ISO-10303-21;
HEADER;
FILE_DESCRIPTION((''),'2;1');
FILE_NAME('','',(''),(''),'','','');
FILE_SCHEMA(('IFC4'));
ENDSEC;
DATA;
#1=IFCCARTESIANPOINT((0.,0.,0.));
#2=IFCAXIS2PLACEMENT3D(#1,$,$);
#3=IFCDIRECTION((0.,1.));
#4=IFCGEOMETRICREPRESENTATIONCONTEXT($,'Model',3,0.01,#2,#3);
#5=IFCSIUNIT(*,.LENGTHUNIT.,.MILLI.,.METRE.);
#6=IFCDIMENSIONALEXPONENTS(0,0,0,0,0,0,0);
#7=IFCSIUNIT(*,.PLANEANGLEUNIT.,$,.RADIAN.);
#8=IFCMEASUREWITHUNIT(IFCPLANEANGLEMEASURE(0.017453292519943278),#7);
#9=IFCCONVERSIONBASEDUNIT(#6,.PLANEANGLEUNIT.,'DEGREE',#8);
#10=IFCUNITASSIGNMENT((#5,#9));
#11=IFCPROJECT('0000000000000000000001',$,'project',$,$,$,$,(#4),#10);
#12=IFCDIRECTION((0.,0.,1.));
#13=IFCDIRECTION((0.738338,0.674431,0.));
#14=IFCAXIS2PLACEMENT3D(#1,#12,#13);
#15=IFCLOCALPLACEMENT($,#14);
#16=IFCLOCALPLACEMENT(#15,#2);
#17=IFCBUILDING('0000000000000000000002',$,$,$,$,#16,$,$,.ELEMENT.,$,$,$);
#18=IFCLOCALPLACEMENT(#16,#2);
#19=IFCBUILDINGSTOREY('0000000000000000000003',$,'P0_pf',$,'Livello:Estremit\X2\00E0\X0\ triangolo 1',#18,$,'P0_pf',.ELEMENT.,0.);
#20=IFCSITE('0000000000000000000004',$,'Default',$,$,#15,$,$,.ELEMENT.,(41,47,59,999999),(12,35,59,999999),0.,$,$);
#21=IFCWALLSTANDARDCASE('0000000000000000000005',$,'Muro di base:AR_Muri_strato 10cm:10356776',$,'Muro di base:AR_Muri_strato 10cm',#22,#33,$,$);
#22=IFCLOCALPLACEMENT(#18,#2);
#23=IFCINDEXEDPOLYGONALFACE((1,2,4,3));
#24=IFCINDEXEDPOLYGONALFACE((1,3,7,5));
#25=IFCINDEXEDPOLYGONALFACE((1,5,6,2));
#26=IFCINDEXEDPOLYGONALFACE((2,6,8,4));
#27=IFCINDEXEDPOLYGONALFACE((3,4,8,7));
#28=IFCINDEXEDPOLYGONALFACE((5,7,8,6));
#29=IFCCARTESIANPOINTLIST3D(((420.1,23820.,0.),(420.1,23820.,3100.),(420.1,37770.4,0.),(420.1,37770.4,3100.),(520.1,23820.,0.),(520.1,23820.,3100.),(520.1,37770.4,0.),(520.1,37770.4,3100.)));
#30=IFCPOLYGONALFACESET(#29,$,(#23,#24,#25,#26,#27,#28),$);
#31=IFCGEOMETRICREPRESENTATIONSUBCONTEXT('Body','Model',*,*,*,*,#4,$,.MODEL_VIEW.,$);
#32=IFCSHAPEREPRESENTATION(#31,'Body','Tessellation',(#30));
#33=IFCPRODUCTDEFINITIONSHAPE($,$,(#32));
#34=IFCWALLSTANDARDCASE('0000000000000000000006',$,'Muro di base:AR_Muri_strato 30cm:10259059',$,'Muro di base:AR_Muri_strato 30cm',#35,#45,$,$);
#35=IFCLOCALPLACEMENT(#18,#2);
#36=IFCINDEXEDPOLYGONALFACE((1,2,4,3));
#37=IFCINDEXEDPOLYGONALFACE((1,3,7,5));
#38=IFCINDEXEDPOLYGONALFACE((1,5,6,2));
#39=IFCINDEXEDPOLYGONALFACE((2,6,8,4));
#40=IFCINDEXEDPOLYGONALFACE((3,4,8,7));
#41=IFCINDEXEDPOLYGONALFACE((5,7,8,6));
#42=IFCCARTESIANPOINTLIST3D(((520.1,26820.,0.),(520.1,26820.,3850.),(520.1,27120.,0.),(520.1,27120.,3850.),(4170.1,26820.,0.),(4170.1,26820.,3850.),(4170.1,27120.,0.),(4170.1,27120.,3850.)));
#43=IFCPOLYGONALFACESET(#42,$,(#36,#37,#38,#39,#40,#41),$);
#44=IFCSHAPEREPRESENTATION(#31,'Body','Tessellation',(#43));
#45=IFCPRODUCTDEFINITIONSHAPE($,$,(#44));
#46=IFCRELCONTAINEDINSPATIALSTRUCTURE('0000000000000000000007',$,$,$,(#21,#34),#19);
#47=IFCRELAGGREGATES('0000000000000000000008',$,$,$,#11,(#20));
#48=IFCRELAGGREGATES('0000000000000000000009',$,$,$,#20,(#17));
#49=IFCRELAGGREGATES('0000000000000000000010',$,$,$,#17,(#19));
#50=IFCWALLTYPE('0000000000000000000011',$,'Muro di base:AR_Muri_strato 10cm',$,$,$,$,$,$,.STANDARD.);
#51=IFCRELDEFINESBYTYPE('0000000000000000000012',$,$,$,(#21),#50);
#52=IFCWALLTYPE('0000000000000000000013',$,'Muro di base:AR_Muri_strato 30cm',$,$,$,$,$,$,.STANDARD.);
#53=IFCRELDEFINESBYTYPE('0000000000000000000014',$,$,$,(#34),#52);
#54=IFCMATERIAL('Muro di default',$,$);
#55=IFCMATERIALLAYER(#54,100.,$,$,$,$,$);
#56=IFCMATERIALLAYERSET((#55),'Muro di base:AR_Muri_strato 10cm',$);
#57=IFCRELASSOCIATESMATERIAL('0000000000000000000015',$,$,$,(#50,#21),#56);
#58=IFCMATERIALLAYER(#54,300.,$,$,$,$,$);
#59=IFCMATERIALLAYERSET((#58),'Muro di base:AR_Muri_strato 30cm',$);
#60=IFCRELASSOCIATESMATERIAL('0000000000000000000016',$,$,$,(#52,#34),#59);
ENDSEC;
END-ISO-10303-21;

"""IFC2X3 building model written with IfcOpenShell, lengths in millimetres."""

from ifc_helpers import new_model, entity, si_unit, converted_unit, direction, frame, frame_2d, origin, place, context, subcontext, project, spatial, rectangle, extrude, material, layer, layer_set, layer_usage, type_object, element, save


model = new_model("IFC2X3")

# Units and contexts
model_context = context("Model", 3, precision=0.01, world=origin(), true_north=direction((0.0, 1.0)))
body_context = subcontext(model_context, "Body", "Model", "MODEL_VIEW")
ifc_project = project(units=[si_unit("LENGTHUNIT", "METRE", prefix="MILLI"), converted_unit("PLANEANGLEUNIT", "DEGREE", entity("IfcPlaneAngleMeasure", 0.017453292519943278), si_unit("PLANEANGLEUNIT", "RADIAN"), dimensions=[0, 0, 0, 0, 0, 0, 0])], contexts=[model_context])

# Site, building, storey
site_placement = place(None, frame((0.0, 0.0, 0.0), z_axis=(0.0, 0.0, 1.0), x_axis=(0.738338, 0.674431, 0.0)))
site = spatial("IfcSite", under=ifc_project, at=site_placement, Name="Default", CompositionType="ELEMENT", RefLatitude=(41, 47, 59, 999999), RefLongitude=(12, 35, 59, 999999), RefElevation=0.0)
building_placement = place(site_placement, origin())
building = spatial("IfcBuilding", under=site, at=building_placement, CompositionType="ELEMENT")
storey_placement = place(building_placement, origin())
storey = spatial("IfcBuildingStorey", under=building, at=storey_placement, Name="P0_pf", ObjectType="Livello:Estremità triangolo 1", LongName="P0_pf", CompositionType="ELEMENT", Elevation=0.0)

# Shared definitions
ifc_material_1 = material(Name="Muro di default")
ifc_layer_1 = layer(ifc_material_1, 100.0)
ifc_layer_set_1 = layer_set([ifc_layer_1], Name="Muro di base:AR_Muri_strato 10cm")
wall_type_1 = type_object("IfcWallType", Name="Muro di base:AR_Muri_strato 10cm", PredefinedType="STANDARD", material=ifc_layer_set_1)

# Walls
ifc_layer_usage_1 = layer_usage(ifc_layer_set_1, "AXIS2", "NEGATIVE", 50.0)
wall_1_placement = place(storey_placement, frame((470.1, 23820.0, 0.0), z_axis=(0.0, 0.0, 1.0), x_axis=(0.0, 1.0, 0.0)))
element("IfcWallStandardCase", 1, at=wall_1_placement, inside=storey, type_object=wall_type_1, material=ifc_layer_usage_1, Name="Muro di base:AR_Muri_strato 10cm:10356776", ObjectType="Muro di base:AR_Muri_strato 10cm", context=body_context, shape_type="SweptSolid", body=[
    extrude(rectangle(XDim=13950.4, YDim=100.0, at=frame_2d((6975.2, 0.0), x_axis=(-1.0, 0.0))), origin(), (0.0, 0.0, 1.0), 3100.0),
])
ifc_layer_2 = layer(ifc_material_1, 300.0)
ifc_layer_set_2 = layer_set([ifc_layer_2], Name="Muro di base:AR_Muri_strato 30cm")
ifc_layer_usage_2 = layer_usage(ifc_layer_set_2, "AXIS2", "NEGATIVE", 150.0)
wall_type_2 = type_object("IfcWallType", Name="Muro di base:AR_Muri_strato 30cm", PredefinedType="STANDARD", material=ifc_layer_set_2)
wall_2_placement = place(storey_placement, frame((4170.1, 26970.0, 0.0), z_axis=(0.0, 0.0, 1.0), x_axis=(-1.0, 0.0, 0.0)))
element("IfcWallStandardCase", 2, at=wall_2_placement, inside=storey, type_object=wall_type_2, material=ifc_layer_usage_2, Name="Muro di base:AR_Muri_strato 30cm:10259059", ObjectType="Muro di base:AR_Muri_strato 30cm", context=body_context, shape_type="SweptSolid", body=[
    extrude(rectangle(XDim=3650.0, YDim=300.0, at=frame_2d((1825.0, 0.0), x_axis=(-1.0, 0.0))), origin(), (0.0, 0.0, 1.0), 3850.0),
])

save(model, "model.ifc")
